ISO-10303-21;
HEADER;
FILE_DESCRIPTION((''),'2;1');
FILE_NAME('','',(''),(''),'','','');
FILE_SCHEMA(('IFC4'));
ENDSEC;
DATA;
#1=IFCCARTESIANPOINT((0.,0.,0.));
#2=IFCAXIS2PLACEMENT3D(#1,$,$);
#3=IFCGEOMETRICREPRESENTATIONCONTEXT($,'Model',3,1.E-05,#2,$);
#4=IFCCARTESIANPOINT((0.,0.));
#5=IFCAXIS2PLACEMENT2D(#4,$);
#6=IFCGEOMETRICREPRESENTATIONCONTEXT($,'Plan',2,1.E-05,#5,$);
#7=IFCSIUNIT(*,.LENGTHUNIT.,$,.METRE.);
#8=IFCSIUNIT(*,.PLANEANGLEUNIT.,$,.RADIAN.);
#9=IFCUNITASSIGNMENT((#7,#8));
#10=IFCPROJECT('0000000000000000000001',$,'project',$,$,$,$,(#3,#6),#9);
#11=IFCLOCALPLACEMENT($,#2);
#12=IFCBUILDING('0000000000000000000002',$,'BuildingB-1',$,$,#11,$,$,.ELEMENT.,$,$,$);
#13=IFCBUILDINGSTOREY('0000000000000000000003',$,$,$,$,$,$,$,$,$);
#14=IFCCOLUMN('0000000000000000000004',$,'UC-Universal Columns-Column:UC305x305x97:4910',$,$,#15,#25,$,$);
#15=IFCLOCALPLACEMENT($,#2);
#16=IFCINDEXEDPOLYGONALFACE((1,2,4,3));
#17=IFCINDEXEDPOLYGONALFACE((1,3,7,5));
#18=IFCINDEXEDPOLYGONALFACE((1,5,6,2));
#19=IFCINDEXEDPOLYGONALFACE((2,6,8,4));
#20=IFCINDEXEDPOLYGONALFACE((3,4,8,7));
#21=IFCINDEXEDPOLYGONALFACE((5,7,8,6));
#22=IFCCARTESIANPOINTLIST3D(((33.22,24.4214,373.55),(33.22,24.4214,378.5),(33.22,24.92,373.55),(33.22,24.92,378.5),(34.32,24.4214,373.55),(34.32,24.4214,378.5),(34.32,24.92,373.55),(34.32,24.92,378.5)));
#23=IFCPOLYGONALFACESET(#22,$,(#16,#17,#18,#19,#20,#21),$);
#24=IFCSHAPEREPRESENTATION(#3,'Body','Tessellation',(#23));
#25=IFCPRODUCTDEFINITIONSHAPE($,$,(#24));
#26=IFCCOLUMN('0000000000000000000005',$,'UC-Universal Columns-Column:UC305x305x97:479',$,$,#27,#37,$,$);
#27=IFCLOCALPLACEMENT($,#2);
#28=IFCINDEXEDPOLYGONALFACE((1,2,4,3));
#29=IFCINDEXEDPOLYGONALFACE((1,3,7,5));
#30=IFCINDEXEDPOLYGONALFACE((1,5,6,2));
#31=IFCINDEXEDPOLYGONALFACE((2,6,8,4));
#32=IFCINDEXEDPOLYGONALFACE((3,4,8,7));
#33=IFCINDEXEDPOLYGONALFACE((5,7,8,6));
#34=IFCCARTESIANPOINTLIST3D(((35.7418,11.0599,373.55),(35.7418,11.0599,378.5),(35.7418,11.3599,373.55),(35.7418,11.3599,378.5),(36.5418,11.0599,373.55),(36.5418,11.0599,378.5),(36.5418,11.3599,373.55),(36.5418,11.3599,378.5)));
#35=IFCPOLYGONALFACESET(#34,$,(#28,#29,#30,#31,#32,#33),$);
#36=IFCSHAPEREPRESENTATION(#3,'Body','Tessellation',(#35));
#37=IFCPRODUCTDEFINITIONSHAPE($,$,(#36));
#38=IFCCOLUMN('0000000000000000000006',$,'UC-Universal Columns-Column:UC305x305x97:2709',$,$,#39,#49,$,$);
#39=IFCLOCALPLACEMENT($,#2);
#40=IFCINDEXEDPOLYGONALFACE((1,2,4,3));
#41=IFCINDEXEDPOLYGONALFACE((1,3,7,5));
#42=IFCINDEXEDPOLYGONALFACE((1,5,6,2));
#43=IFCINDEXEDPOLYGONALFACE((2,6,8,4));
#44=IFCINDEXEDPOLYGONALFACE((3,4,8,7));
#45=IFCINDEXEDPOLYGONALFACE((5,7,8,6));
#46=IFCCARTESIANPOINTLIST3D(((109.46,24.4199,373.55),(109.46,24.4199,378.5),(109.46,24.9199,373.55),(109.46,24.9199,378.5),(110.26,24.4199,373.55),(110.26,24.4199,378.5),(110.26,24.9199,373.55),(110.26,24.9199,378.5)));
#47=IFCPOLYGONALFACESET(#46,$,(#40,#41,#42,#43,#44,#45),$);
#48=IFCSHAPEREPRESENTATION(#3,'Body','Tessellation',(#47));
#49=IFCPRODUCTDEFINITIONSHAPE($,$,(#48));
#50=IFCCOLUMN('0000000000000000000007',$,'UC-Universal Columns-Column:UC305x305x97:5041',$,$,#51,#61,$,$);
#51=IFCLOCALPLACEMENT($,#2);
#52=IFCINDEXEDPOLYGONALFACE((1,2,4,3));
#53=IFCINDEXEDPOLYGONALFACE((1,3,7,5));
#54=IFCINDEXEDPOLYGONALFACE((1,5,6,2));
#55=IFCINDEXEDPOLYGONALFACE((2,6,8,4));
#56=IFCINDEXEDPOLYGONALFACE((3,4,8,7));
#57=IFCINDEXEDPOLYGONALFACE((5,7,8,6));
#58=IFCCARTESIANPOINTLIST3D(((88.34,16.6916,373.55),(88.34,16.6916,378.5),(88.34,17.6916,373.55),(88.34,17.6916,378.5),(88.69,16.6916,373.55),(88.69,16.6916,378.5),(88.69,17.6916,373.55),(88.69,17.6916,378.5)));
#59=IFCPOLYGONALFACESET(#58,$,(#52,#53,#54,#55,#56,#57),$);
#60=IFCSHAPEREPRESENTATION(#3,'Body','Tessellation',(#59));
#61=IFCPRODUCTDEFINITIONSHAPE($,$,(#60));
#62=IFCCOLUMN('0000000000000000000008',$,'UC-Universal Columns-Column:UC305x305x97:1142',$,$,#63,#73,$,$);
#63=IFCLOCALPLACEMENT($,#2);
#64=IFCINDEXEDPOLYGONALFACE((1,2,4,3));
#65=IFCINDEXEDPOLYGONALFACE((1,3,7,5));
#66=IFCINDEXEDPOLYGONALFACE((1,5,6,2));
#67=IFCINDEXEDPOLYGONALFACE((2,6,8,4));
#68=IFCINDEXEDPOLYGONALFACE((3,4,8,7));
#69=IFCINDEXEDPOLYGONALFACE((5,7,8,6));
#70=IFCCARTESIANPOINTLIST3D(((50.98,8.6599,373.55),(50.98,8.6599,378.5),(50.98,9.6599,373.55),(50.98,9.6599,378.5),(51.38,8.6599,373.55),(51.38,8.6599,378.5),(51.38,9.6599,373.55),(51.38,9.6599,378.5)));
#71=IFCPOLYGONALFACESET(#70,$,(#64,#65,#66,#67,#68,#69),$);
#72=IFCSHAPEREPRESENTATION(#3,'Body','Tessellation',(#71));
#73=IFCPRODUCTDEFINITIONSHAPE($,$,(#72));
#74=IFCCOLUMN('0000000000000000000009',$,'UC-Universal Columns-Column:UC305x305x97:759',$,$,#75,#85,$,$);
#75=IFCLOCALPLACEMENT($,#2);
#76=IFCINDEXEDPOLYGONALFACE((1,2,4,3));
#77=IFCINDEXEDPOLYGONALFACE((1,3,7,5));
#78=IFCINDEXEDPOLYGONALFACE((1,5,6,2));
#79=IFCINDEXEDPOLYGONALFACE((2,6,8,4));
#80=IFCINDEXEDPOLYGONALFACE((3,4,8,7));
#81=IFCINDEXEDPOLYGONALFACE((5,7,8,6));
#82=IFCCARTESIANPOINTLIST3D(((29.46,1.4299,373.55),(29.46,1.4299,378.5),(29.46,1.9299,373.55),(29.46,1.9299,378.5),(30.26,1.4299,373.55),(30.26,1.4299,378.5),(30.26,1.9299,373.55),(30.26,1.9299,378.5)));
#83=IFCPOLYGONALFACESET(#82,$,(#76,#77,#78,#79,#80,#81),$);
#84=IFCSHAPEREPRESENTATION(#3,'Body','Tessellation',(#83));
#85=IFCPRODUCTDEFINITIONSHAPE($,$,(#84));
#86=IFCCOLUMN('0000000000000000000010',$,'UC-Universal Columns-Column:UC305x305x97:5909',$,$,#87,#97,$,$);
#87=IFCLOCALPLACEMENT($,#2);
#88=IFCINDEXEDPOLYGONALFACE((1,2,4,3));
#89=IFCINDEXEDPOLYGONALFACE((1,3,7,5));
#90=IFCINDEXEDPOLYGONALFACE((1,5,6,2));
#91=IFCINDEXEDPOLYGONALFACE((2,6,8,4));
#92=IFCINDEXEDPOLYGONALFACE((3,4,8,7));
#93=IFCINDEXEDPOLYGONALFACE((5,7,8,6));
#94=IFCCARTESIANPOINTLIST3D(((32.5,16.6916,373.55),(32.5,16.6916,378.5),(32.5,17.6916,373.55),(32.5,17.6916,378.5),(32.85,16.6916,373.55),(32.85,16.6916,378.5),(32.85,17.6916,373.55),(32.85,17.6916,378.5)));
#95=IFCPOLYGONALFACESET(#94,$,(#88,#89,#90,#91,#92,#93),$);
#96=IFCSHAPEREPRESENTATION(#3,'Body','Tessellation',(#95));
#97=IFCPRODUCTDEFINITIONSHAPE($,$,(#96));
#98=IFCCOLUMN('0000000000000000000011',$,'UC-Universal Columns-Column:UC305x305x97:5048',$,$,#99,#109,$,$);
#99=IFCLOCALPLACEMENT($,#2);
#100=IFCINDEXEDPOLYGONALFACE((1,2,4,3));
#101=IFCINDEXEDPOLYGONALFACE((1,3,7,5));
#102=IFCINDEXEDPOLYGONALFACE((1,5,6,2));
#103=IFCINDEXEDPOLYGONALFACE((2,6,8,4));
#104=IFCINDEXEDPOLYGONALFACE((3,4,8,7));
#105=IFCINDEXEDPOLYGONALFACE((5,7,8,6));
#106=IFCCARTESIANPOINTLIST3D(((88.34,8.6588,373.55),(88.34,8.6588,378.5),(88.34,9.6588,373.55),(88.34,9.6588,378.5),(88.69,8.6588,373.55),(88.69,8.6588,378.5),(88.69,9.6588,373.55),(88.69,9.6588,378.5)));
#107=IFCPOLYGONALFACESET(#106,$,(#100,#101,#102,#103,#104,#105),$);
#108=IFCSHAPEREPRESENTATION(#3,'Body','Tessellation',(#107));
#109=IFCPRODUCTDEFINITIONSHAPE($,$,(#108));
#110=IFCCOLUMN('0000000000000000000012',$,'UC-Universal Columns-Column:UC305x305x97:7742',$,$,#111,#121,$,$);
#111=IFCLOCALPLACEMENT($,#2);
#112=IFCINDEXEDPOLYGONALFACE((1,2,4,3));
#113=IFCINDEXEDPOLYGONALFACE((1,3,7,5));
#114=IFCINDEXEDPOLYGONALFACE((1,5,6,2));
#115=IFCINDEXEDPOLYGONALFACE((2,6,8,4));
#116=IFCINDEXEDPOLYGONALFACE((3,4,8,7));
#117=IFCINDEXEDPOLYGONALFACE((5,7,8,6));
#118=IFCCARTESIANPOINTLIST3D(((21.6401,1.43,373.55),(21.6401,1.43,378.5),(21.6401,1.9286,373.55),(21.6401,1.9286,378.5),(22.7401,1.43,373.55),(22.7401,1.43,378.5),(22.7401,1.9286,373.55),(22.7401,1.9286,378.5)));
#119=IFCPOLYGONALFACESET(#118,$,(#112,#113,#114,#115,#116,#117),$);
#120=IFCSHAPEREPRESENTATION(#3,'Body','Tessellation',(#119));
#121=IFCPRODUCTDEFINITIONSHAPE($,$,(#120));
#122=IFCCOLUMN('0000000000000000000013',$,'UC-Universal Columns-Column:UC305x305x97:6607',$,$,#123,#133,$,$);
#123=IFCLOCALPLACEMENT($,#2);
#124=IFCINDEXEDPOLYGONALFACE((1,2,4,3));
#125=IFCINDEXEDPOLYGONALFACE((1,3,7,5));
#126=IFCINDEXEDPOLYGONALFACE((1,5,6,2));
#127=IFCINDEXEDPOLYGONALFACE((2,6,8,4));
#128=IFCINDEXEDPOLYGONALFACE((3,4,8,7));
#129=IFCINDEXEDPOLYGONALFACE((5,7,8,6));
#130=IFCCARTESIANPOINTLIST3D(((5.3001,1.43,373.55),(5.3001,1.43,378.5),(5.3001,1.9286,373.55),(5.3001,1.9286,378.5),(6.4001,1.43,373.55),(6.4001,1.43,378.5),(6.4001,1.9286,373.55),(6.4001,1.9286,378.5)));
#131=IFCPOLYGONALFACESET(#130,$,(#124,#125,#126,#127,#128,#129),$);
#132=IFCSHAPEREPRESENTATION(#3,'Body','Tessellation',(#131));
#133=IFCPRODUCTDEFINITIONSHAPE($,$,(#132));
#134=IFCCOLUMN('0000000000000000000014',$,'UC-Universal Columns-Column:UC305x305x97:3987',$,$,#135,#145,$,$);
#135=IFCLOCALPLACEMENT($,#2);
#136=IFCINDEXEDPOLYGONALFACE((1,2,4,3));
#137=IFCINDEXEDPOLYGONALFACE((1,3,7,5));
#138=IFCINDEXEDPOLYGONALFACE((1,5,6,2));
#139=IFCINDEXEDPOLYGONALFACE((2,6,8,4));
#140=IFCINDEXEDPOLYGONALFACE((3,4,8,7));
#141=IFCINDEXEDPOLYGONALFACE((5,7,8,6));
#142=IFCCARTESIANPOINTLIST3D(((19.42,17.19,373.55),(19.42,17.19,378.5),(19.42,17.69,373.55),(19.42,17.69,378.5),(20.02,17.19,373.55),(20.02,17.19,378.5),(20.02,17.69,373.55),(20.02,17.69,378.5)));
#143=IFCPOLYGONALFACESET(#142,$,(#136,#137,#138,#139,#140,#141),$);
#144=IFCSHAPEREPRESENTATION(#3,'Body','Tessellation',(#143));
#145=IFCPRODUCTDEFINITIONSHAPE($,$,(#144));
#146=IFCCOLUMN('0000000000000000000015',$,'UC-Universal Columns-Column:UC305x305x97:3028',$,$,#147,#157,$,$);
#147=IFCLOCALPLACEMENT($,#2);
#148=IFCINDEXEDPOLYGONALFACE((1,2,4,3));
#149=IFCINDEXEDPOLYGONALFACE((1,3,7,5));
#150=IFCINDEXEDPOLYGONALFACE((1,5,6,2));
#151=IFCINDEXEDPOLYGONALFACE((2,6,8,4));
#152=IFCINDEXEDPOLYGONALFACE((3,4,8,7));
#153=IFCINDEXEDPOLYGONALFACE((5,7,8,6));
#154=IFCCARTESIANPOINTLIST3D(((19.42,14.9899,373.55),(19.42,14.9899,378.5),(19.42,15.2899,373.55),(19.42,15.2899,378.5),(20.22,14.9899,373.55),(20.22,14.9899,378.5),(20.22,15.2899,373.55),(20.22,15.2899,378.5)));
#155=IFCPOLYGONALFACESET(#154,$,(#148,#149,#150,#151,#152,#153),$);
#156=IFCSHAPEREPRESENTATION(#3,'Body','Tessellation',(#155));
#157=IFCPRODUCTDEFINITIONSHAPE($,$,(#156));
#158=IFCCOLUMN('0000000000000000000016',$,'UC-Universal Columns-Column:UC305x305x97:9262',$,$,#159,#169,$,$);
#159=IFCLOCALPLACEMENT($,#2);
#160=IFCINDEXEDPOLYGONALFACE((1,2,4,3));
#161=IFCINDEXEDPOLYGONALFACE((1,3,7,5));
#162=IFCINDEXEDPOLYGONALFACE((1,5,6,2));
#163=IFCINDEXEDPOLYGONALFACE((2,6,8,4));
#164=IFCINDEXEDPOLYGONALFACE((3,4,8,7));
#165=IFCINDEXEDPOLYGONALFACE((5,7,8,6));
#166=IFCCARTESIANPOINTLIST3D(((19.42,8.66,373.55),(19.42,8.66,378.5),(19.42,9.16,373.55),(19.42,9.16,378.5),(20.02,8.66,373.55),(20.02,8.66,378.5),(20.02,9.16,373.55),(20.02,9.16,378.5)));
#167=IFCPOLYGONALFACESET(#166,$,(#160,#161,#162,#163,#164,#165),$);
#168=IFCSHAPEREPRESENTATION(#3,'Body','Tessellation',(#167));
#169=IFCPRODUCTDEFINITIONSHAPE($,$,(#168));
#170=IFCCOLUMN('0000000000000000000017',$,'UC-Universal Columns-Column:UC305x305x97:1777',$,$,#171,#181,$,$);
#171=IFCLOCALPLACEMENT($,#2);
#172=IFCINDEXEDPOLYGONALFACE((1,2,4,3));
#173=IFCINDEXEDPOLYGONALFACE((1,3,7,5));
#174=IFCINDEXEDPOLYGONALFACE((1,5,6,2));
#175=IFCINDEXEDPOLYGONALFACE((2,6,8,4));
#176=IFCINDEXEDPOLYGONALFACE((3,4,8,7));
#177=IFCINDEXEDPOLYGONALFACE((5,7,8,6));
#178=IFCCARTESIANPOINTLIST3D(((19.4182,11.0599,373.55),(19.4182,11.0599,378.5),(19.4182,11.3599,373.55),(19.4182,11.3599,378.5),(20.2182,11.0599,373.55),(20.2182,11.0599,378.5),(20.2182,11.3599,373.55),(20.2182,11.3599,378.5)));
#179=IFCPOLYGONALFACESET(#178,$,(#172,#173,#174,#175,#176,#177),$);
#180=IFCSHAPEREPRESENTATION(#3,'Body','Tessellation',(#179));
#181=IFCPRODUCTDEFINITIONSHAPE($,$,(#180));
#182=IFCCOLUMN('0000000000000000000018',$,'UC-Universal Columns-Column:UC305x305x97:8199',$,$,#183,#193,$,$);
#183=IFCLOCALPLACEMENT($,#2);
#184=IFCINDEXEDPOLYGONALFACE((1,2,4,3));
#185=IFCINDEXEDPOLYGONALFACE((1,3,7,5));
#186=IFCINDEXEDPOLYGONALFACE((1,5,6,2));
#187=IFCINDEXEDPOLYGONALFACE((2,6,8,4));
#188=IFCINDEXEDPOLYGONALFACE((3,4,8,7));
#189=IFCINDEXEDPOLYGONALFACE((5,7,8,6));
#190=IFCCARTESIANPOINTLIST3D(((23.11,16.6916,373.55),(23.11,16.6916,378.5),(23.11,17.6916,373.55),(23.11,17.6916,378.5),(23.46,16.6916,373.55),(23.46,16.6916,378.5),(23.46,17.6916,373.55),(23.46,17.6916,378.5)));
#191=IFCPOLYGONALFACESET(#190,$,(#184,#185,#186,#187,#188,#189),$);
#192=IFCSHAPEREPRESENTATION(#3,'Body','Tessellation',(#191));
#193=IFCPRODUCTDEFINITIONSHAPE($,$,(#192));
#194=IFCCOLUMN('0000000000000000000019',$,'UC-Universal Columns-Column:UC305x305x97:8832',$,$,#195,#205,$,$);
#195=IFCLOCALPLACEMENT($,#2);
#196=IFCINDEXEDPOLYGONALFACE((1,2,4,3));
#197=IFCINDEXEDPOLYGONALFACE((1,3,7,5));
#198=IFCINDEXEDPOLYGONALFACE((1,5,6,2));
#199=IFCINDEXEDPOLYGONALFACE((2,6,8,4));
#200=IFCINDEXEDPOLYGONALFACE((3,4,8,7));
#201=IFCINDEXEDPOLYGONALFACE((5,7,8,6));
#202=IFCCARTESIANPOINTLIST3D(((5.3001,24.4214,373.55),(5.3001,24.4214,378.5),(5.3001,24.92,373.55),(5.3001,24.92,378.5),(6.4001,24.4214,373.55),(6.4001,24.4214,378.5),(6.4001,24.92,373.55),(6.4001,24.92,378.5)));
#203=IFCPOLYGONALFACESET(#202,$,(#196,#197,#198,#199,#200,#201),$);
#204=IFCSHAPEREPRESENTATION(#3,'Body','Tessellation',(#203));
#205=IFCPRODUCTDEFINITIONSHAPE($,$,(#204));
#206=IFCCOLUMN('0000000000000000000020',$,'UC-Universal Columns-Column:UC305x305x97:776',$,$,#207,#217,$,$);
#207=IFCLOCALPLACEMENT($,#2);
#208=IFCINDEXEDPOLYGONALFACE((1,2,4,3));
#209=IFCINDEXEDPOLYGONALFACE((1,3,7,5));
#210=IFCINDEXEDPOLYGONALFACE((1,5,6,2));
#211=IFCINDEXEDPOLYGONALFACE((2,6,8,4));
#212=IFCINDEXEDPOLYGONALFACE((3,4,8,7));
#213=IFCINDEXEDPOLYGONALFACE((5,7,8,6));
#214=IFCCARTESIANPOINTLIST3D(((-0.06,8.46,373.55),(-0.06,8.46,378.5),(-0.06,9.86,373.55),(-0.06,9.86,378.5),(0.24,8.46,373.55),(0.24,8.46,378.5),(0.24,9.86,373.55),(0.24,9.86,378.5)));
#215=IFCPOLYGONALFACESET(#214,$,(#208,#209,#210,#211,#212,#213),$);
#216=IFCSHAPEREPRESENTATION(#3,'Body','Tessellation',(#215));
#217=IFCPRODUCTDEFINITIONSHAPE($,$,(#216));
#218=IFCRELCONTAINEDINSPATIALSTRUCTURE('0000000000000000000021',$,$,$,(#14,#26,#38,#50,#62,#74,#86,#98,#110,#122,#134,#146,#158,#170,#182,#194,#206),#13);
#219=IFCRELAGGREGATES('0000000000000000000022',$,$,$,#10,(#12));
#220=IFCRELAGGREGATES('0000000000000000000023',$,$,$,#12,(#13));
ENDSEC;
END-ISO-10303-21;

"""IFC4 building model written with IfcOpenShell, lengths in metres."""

from ifc_helpers import new_model, si_unit, origin, origin_2d, place, context, project, spatial, polyline, outline, extrude, element, save


model = new_model("IFC4")

# Units and contexts
model_context = context("Model", 3, precision=1e-05, world=origin())
plan_context = context("Plan", 2, precision=1e-05, world=origin_2d())
ifc_project = project(units=[si_unit("LENGTHUNIT", "METRE"), si_unit("PLANEANGLEUNIT", "RADIAN")], contexts=[model_context, plan_context])

# Building, storey
building_placement = place(None, origin())
building = spatial("IfcBuilding", under=ifc_project, at=building_placement, Name="BuildingB-1", CompositionType="ELEMENT")
storey = spatial("IfcBuildingStorey", under=building)

# Columns
element("IfcColumn", 1, inside=storey, Name="UC-Universal Columns-Column:UC305x305x97:4910", context=model_context, shape_type="SweptSolid", body=[
    extrude(outline(polyline([(34.32, 24.4214, 378.5), (33.22, 24.4214, 378.5), (33.22, 24.92, 378.5), (34.32, 24.92, 378.5), (34.32, 24.4214, 378.5)])), None, (0.0, 0.0, -1.0), 4.95),
])
element("IfcColumn", 2, inside=storey, Name="UC-Universal Columns-Column:UC305x305x97:479", context=model_context, shape_type="SweptSolid", body=[
    extrude(outline(polyline([(36.5418, 11.0599, 378.5), (35.7418, 11.0599, 378.5), (35.7418, 11.3599, 378.5), (36.5418, 11.3599, 378.5), (36.5418, 11.0599, 378.5)])), None, (0.0, 0.0, -1.0), 4.95),
])
element("IfcColumn", 3, inside=storey, Name="UC-Universal Columns-Column:UC305x305x97:2709", context=model_context, shape_type="SweptSolid", body=[
    extrude(outline(polyline([(110.26, 24.4199, 378.5), (109.46, 24.4199, 378.5), (109.46, 24.9199, 378.5), (110.26, 24.9199, 378.5), (110.26, 24.4199, 378.5)])), None, (0.0, 0.0, -1.0), 4.95),
])
element("IfcColumn", 4, inside=storey, Name="UC-Universal Columns-Column:UC305x305x97:5041", context=model_context, shape_type="SweptSolid", body=[
    extrude(outline(polyline([(88.34, 17.6916, 378.5), (88.69, 17.6916, 378.5), (88.69, 16.6916, 378.5), (88.34, 16.6916, 378.5), (88.34, 17.6916, 378.5)])), None, (0.0, 0.0, -1.0), 4.95),
])
element("IfcColumn", 5, inside=storey, Name="UC-Universal Columns-Column:UC305x305x97:1142", context=model_context, shape_type="SweptSolid", body=[
    extrude(outline(polyline([(51.38, 8.6599, 378.5), (50.98, 8.6599, 378.5), (50.98, 9.6599, 378.5), (51.38, 9.6599, 378.5), (51.38, 8.6599, 378.5)])), None, (0.0, 0.0, -1.0), 4.95),
])
element("IfcColumn", 6, inside=storey, Name="UC-Universal Columns-Column:UC305x305x97:759", context=model_context, shape_type="SweptSolid", body=[
    extrude(outline(polyline([(30.26, 1.4299, 378.5), (29.46, 1.4299, 378.5), (29.46, 1.9299, 378.5), (30.26, 1.9299, 378.5), (30.26, 1.4299, 378.5)])), None, (0.0, 0.0, -1.0), 4.95),
])
element("IfcColumn", 7, inside=storey, Name="UC-Universal Columns-Column:UC305x305x97:5909", context=model_context, shape_type="SweptSolid", body=[
    extrude(outline(polyline([(32.5, 17.6916, 378.5), (32.85, 17.6916, 378.5), (32.85, 16.6916, 378.5), (32.5, 16.6916, 378.5), (32.5, 17.6916, 378.5)])), None, (0.0, 0.0, -1.0), 4.95),
])
element("IfcColumn", 8, inside=storey, Name="UC-Universal Columns-Column:UC305x305x97:5048", context=model_context, shape_type="SweptSolid", body=[
    extrude(outline(polyline([(88.34, 8.6588, 378.5), (88.69, 8.6588, 378.5), (88.69, 9.6588, 378.5), (88.34, 9.6588, 378.5), (88.34, 8.6588, 378.5)])), None, (0.0, 0.0, -1.0), 4.95),
])
element("IfcColumn", 9, inside=storey, Name="UC-Universal Columns-Column:UC305x305x97:7742", context=model_context, shape_type="SweptSolid", body=[
    extrude(outline(polyline([(21.6401, 1.43, 378.5), (22.7401, 1.43, 378.5), (22.7401, 1.9286, 378.5), (21.6401, 1.9286, 378.5), (21.6401, 1.43, 378.5)])), None, (0.0, 0.0, -1.0), 4.95),
])
element("IfcColumn", 10, inside=storey, Name="UC-Universal Columns-Column:UC305x305x97:6607", context=model_context, shape_type="SweptSolid", body=[
    extrude(outline(polyline([(5.3001, 1.43, 378.5), (6.4001, 1.43, 378.5), (6.4001, 1.9286, 378.5), (5.3001, 1.9286, 378.5), (5.3001, 1.43, 378.5)])), None, (0.0, 0.0, -1.0), 4.95),
])
element("IfcColumn", 11, inside=storey, Name="UC-Universal Columns-Column:UC305x305x97:3987", context=model_context, shape_type="SweptSolid", body=[
    extrude(outline(polyline([(19.42, 17.69, 378.5), (20.02, 17.69, 378.5), (20.02, 17.19, 378.5), (19.42, 17.19, 378.5), (19.42, 17.69, 378.5)])), None, (0.0, 0.0, -1.0), 4.95),
])
element("IfcColumn", 12, inside=storey, Name="UC-Universal Columns-Column:UC305x305x97:3028", context=model_context, shape_type="SweptSolid", body=[
    extrude(outline(polyline([(19.42, 15.2899, 378.5), (20.22, 15.2899, 378.5), (20.22, 14.9899, 378.5), (19.42, 14.9899, 378.5), (19.42, 15.2899, 378.5)])), None, (0.0, 0.0, -1.0), 4.95),
])
element("IfcColumn", 13, inside=storey, Name="UC-Universal Columns-Column:UC305x305x97:9262", context=model_context, shape_type="SweptSolid", body=[
    extrude(outline(polyline([(19.42, 8.66, 378.5), (20.02, 8.66, 378.5), (20.02, 9.16, 378.5), (19.42, 9.16, 378.5), (19.42, 8.66, 378.5)])), None, (0.0, 0.0, -1.0), 4.95),
])
element("IfcColumn", 14, inside=storey, Name="UC-Universal Columns-Column:UC305x305x97:1777", context=model_context, shape_type="SweptSolid", body=[
    extrude(outline(polyline([(19.4182, 11.0599, 378.5), (20.2182, 11.0599, 378.5), (20.2182, 11.3599, 378.5), (19.4182, 11.3599, 378.5), (19.4182, 11.0599, 378.5)])), None, (0.0, 0.0, -1.0), 4.95),
])
element("IfcColumn", 15, inside=storey, Name="UC-Universal Columns-Column:UC305x305x97:8199", context=model_context, shape_type="SweptSolid", body=[
    extrude(outline(polyline([(23.46, 17.6916, 378.5), (23.11, 17.6916, 378.5), (23.11, 16.6916, 378.5), (23.46, 16.6916, 378.5), (23.46, 17.6916, 378.5)])), None, (0.0, 0.0, -1.0), 4.95),
])
element("IfcColumn", 16, inside=storey, Name="UC-Universal Columns-Column:UC305x305x97:8832", context=model_context, shape_type="SweptSolid", body=[
    extrude(outline(polyline([(5.3001, 24.4214, 378.5), (6.4001, 24.4214, 378.5), (6.4001, 24.92, 378.5), (5.3001, 24.92, 378.5), (5.3001, 24.4214, 378.5)])), None, (0.0, 0.0, -1.0), 4.95),
])
element("IfcColumn", 17, inside=storey, Name="UC-Universal Columns-Column:UC305x305x97:776", context=model_context, shape_type="SweptSolid", body=[
    extrude(outline(polyline([(-0.06, 8.46, 378.5), (0.24, 8.46, 378.5), (0.24, 9.86, 378.5), (-0.06, 9.86, 378.5), (-0.06, 8.46, 378.5)])), None, (0.0, 0.0, -1.0), 4.95),
])

save(model, "model.ifc")
